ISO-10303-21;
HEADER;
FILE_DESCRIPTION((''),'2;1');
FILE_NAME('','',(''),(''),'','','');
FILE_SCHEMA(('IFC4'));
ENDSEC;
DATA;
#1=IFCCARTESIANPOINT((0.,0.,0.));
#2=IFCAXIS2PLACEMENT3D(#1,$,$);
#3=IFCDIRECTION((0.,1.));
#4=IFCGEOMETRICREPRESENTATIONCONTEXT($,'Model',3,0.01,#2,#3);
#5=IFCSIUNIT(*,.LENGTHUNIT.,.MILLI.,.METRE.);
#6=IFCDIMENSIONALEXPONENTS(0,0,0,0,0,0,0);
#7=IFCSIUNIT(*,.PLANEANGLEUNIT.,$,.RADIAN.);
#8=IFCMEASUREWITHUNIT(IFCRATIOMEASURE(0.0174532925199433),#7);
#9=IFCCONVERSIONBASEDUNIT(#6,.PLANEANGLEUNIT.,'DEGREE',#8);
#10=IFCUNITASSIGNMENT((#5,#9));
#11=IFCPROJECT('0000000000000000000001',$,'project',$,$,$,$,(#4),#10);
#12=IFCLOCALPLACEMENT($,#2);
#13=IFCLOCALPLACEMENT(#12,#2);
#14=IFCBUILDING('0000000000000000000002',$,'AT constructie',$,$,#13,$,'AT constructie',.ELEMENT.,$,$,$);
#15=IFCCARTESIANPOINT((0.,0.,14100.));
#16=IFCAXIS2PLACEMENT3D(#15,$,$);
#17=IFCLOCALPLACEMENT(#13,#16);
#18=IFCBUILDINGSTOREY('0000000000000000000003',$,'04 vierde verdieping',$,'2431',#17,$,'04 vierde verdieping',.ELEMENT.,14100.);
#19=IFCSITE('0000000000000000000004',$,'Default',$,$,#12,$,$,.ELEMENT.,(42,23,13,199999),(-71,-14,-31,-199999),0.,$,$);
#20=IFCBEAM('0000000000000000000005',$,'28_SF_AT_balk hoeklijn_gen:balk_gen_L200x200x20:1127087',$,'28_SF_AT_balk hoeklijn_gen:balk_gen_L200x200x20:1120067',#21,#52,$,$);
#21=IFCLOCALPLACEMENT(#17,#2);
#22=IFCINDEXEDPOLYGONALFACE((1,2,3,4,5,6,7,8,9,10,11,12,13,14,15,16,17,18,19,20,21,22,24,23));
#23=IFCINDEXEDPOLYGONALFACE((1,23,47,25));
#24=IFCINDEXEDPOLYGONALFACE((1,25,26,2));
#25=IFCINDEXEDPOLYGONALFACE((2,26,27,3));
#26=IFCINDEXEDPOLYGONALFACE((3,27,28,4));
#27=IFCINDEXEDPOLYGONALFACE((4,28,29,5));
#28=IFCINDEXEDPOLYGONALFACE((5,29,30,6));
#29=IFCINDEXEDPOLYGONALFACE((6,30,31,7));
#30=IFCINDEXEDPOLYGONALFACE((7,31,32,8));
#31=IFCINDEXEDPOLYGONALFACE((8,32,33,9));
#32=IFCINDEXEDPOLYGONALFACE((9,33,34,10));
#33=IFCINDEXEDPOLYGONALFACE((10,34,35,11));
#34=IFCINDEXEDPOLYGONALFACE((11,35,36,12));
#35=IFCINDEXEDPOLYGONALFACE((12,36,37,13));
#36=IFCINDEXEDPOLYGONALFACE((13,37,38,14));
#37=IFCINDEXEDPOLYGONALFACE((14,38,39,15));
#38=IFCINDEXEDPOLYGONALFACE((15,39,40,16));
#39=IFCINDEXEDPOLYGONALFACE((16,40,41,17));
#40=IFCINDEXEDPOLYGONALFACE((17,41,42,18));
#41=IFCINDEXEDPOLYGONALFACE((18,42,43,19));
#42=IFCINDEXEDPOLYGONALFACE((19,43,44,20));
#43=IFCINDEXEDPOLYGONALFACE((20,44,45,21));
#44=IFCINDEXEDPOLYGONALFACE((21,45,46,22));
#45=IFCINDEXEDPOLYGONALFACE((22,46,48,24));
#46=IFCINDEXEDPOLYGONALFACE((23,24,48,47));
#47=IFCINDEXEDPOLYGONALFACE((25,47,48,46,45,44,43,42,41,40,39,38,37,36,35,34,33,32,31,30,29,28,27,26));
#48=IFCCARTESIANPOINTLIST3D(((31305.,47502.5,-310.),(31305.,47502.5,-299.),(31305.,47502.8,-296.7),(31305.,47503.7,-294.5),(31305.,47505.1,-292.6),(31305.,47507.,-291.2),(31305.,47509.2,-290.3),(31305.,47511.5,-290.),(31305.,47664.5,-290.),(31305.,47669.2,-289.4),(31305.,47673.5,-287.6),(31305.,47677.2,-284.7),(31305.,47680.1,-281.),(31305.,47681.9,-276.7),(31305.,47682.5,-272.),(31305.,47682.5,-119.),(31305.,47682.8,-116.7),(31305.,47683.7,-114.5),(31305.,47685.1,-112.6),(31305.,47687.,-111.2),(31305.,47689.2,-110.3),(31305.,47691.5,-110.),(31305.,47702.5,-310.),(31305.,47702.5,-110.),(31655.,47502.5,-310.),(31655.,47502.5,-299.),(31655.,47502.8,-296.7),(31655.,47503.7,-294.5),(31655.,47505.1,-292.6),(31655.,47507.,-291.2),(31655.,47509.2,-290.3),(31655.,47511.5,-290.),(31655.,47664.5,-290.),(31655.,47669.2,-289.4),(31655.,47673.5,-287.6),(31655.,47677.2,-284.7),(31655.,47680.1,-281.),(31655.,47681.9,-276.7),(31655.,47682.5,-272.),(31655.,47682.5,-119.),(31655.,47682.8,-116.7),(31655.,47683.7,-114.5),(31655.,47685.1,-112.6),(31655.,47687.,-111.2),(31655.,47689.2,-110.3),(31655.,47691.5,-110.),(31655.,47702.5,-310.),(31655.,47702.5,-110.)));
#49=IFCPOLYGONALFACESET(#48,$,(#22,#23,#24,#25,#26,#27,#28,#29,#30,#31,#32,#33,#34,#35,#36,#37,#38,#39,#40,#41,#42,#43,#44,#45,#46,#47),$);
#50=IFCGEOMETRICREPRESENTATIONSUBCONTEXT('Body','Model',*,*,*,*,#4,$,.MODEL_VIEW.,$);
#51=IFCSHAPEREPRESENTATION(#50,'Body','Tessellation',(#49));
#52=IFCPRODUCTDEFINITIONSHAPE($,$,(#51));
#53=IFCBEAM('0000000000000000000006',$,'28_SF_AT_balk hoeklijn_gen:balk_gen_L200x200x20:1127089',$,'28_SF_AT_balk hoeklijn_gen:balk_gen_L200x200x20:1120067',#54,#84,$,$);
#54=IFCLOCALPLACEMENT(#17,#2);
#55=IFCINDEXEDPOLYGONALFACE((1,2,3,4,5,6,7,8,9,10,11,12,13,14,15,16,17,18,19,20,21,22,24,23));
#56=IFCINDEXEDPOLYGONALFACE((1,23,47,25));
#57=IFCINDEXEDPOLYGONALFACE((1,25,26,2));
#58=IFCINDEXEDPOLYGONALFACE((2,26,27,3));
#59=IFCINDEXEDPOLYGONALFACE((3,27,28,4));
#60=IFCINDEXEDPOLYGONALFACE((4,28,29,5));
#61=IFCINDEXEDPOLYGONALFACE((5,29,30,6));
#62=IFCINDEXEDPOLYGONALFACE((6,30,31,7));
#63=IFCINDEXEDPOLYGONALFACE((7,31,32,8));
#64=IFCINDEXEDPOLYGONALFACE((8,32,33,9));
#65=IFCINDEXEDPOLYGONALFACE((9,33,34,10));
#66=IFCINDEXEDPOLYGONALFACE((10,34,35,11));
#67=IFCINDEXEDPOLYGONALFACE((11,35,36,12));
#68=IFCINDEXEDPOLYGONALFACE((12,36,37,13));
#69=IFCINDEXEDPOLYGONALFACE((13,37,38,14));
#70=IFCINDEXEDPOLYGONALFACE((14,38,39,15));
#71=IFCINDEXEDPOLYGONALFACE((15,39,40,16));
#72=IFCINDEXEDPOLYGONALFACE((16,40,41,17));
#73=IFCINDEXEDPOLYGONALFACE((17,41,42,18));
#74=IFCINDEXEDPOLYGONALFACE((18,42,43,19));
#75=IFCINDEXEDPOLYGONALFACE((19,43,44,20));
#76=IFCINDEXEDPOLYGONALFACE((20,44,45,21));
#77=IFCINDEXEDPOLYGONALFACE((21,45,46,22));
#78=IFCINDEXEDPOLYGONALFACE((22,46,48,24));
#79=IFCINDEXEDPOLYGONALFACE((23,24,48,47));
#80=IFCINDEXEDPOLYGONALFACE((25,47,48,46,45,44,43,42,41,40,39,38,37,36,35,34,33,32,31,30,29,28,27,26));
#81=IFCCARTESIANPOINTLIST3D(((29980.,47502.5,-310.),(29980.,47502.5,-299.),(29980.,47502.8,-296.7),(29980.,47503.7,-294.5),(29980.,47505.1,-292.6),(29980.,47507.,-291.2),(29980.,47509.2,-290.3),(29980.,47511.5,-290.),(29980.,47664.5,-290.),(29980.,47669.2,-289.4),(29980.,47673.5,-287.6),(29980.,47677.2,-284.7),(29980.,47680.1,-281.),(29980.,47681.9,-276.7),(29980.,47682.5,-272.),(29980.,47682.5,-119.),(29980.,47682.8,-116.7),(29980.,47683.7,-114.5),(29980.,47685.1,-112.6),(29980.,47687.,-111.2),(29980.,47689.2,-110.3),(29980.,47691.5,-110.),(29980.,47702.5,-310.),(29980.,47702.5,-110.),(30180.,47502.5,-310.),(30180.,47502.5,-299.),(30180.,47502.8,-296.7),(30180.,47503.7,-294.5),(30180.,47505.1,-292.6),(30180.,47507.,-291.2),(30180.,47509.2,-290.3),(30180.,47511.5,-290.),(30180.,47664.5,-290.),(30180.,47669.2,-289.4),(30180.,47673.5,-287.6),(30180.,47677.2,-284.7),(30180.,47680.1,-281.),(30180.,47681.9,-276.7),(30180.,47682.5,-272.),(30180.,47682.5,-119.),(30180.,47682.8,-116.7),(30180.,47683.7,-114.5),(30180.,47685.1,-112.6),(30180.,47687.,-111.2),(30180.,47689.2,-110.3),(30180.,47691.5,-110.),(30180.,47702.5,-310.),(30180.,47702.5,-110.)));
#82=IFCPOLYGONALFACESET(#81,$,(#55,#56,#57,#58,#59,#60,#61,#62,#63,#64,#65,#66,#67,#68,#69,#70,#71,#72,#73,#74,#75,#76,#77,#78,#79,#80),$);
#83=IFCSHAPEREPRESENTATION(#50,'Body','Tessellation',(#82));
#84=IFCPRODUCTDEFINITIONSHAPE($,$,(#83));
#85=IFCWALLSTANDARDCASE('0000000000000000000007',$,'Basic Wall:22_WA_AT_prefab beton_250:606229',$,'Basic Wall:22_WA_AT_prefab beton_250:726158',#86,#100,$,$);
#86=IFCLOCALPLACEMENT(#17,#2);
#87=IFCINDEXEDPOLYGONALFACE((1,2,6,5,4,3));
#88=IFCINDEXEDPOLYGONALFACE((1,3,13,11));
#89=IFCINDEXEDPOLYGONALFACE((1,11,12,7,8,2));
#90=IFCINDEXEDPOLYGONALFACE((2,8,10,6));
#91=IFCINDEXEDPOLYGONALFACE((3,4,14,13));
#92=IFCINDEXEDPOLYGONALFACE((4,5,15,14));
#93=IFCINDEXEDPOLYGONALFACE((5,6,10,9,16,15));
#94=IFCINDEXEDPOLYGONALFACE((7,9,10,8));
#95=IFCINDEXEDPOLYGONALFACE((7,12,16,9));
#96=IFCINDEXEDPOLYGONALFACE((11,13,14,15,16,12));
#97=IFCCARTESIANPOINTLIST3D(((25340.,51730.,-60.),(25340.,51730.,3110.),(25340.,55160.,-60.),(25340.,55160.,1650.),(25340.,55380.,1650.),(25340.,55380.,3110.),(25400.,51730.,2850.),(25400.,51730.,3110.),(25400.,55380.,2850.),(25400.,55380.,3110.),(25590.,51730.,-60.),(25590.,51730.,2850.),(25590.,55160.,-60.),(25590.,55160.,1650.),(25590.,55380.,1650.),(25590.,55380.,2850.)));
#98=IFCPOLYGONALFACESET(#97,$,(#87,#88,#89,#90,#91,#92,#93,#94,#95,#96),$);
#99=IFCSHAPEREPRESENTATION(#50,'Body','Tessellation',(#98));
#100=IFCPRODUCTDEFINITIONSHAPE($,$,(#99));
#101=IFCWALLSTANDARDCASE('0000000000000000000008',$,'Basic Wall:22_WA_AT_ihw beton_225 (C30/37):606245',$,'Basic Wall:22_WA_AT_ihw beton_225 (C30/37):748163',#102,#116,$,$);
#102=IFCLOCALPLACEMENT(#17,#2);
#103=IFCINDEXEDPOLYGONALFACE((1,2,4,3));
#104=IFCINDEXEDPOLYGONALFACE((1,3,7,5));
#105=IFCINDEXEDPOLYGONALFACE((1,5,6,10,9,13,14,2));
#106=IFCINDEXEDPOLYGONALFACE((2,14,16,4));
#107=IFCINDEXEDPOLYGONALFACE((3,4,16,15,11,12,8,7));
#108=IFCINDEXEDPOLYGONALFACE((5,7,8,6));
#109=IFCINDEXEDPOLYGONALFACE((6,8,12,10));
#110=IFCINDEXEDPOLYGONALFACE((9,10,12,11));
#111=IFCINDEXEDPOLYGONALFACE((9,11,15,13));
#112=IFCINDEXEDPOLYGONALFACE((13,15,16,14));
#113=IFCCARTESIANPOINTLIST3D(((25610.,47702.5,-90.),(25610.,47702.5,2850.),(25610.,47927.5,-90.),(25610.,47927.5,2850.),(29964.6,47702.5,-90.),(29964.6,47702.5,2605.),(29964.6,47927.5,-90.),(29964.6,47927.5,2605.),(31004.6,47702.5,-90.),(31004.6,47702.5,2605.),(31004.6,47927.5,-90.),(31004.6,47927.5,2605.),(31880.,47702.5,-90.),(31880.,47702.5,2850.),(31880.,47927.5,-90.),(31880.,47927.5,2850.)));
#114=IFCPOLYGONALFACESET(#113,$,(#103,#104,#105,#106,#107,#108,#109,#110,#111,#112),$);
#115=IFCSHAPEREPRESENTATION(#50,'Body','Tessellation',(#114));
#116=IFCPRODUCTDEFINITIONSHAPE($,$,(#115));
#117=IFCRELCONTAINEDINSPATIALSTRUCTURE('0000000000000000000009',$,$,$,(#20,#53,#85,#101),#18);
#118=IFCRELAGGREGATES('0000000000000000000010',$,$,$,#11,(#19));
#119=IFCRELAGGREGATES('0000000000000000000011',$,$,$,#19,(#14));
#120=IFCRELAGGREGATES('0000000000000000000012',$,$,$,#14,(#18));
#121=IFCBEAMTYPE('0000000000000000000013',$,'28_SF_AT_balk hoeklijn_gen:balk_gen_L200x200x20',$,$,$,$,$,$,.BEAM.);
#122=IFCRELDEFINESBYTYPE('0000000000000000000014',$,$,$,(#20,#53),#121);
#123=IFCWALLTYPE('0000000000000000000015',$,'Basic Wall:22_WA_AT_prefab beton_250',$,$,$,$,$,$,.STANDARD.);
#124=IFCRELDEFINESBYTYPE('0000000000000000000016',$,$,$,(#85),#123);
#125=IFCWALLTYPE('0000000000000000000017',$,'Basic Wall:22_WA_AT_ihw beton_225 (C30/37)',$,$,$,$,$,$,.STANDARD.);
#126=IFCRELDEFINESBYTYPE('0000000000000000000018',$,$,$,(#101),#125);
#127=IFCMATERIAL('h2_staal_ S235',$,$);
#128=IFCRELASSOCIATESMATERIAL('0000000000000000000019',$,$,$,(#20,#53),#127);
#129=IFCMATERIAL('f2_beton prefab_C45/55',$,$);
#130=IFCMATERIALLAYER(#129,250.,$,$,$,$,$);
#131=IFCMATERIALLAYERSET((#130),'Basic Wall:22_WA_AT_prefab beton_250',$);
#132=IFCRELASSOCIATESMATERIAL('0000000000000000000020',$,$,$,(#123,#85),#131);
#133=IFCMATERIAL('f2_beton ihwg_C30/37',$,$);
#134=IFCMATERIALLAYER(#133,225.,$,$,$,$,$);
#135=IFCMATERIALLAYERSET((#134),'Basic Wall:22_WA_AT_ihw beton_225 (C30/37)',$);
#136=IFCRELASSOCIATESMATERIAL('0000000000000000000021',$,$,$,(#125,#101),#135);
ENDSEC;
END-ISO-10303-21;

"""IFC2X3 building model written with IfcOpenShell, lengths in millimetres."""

from ifc_helpers import new_model, entity, si_unit, converted_unit, direction, frame, frame_2d, origin, origin_2d_with_axis, place, context, subcontext, project, spatial, polyline, circle_curve, parameter, trimmed, segment, composite_curve, rectangle, outline, extrude, material, layer, layer_set, layer_usage, type_object, element, save


model = new_model("IFC2X3")

# Units and contexts
model_context = context("Model", 3, precision=0.01, world=origin(), true_north=direction((0.0, 1.0)))
body_context = subcontext(model_context, "Body", "Model", "MODEL_VIEW")
ifc_project = project(units=[si_unit("LENGTHUNIT", "METRE", prefix="MILLI"), converted_unit("PLANEANGLEUNIT", "DEGREE", entity("IfcRatioMeasure", 0.0174532925199433), si_unit("PLANEANGLEUNIT", "RADIAN"), dimensions=[0, 0, 0, 0, 0, 0, 0])], contexts=[model_context])

# Site, building, storey
site_placement = place(None, origin())
site = spatial("IfcSite", under=ifc_project, at=site_placement, Name="Default", CompositionType="ELEMENT", RefLatitude=(42, 23, 13, 199999), RefLongitude=(-71, -14, -31, -199999), RefElevation=0.0)
building_placement = place(site_placement, origin())
building = spatial("IfcBuilding", under=site, at=building_placement, Name="AT constructie", LongName="AT constructie", CompositionType="ELEMENT")
storey_placement = place(building_placement, frame((0.0, 0.0, 14100.0)))
storey = spatial("IfcBuildingStorey", under=building, at=storey_placement, Name="04 vierde verdieping", ObjectType="2431", LongName="04 vierde verdieping", CompositionType="ELEMENT", Elevation=14100.0)

# Shared definitions
ifc_material_1 = material(Name="f2_beton prefab_C45/55")

# Beams
ifc_material_2 = material(Name="h2_staal_ S235")
beam_type_1 = type_object("IfcBeamType", Name="28_SF_AT_balk hoeklijn_gen:balk_gen_L200x200x20", PredefinedType="BEAM")
beam_1_placement = place(storey_placement, frame((31655.0, 47702.5, -70.0), z_axis=(0.0, 0.0, 1.0), x_axis=(-1.0, 0.0, 0.0)))
element("IfcBeam", 1, at=beam_1_placement, inside=storey, type_object=beam_type_1, material=ifc_material_2, Name="28_SF_AT_balk hoeklijn_gen:balk_gen_L200x200x20:1127087", ObjectType="28_SF_AT_balk hoeklijn_gen:balk_gen_L200x200x20:1120067", context=body_context, shape_type="SweptSolid", body=[
    extrude(outline(composite_curve([segment(polyline([(-124.4, -75.6), (75.6, -75.6)]), True, "CONTINUOUS"), segment(polyline([(75.6, -75.6), (75.6, 124.4)]), True, "CONTINUOUS"), segment(polyline([(75.6, 124.4), (64.6, 124.4)]), True, "CONTINUOUS"), segment(trimmed(circle_curve(frame_2d((64.6, 115.4), x_axis=(0.0, 1.0)), 9.0), [parameter(0.0)], [parameter(90.0)], True, "PARAMETER"), True, "CONTINUOUS"), segment(polyline([(55.6, 115.4), (55.6, -37.6)]), True, "CONTINUOUS"), segment(trimmed(circle_curve(frame_2d((37.6, -37.6), x_axis=(1.0, 0.0)), 18.0), [parameter(270.0)], [parameter(0.0)], True, "PARAMETER"), False, "CONTINUOUS"), segment(polyline([(37.6, -55.6), (-115.4, -55.6)]), True, "CONTINUOUS"), segment(trimmed(circle_curve(frame_2d((-115.4, -64.6), x_axis=(0.0, 1.0)), 9.0), [parameter(0.0)], [parameter(90.0)], True, "PARAMETER"), True, "CONTINUOUS"), segment(polyline([(-124.4, -64.6), (-124.4, -75.6)]), True, "CONTINUOUS")], self_intersect=False)), frame((0.0, 75.6, -164.4), z_axis=(1.0, 0.0, 0.0), x_axis=(0.0, 0.0, -1.0)), (0.0, 0.0, 1.0), 350.0),
])
beam_2_placement = place(storey_placement, frame((30180.0, 47702.5, -70.0), z_axis=(0.0, 0.0, 1.0), x_axis=(-1.0, 0.0, 0.0)))
element("IfcBeam", 2, at=beam_2_placement, inside=storey, type_object=beam_type_1, material=ifc_material_2, Name="28_SF_AT_balk hoeklijn_gen:balk_gen_L200x200x20:1127089", ObjectType="28_SF_AT_balk hoeklijn_gen:balk_gen_L200x200x20:1120067", context=body_context, shape_type="SweptSolid", body=[
    extrude(outline(composite_curve([segment(polyline([(-124.4, -75.6), (75.6, -75.6)]), True, "CONTINUOUS"), segment(polyline([(75.6, -75.6), (75.6, 124.4)]), True, "CONTINUOUS"), segment(polyline([(75.6, 124.4), (64.6, 124.4)]), True, "CONTINUOUS"), segment(trimmed(circle_curve(frame_2d((64.6, 115.4), x_axis=(0.0, 1.0)), 9.0), [parameter(0.0)], [parameter(90.0)], True, "PARAMETER"), True, "CONTINUOUS"), segment(polyline([(55.6, 115.4), (55.6, -37.6)]), True, "CONTINUOUS"), segment(trimmed(circle_curve(frame_2d((37.6, -37.6), x_axis=(1.0, 0.0)), 18.0), [parameter(270.0)], [parameter(0.0)], True, "PARAMETER"), False, "CONTINUOUS"), segment(polyline([(37.6, -55.6), (-115.4, -55.6)]), True, "CONTINUOUS"), segment(trimmed(circle_curve(frame_2d((-115.4, -64.6), x_axis=(0.0, 1.0)), 9.0), [parameter(0.0)], [parameter(90.0)], True, "PARAMETER"), True, "CONTINUOUS"), segment(polyline([(-124.4, -64.6), (-124.4, -75.6)]), True, "CONTINUOUS")], self_intersect=False)), frame((0.0, 75.6, -164.4), z_axis=(1.0, 0.0, 0.0), x_axis=(0.0, 0.0, -1.0)), (0.0, 0.0, 1.0), 200.0),
])

# Wall, openings
ifc_layer_1 = layer(ifc_material_1, 250.0)
ifc_layer_set_1 = layer_set([ifc_layer_1], Name="Basic Wall:22_WA_AT_prefab beton_250")
ifc_layer_usage_1 = layer_usage(ifc_layer_set_1, "AXIS2", "NEGATIVE", 125.0)
wall_type_1 = type_object("IfcWallType", Name="Basic Wall:22_WA_AT_prefab beton_250", PredefinedType="STANDARD", material=ifc_layer_set_1)
wall_1_placement = place(storey_placement, frame((25465.0, 55380.0, -60.0), z_axis=(0.0, 0.0, 1.0), x_axis=(0.0, -1.0, 0.0)))
wall_1 = element("IfcWallStandardCase", 3, at=wall_1_placement, inside=storey, type_object=wall_type_1, material=ifc_layer_usage_1, Name="Basic Wall:22_WA_AT_prefab beton_250:606229", ObjectType="Basic Wall:22_WA_AT_prefab beton_250:726158", context=body_context, shape_type="SweptSolid", body=[
    extrude(rectangle(XDim=3650.0, YDim=250.0, at=frame_2d((1825.0, 0.0), x_axis=(-1.0, 0.0))), origin(), (0.0, 0.0, 1.0), 3170.0),
])
opening_1_placement = place(wall_1_placement, origin())
element("IfcOpeningElement", 4, at=opening_1_placement, cuts=wall_1, ObjectType="Recess", context=body_context, shape_type="SweptSolid", body=[
    extrude(rectangle(XDim=260.0, YDim=3900.0, at=frame_2d((0.0, 0.0), x_axis=(0.0, 1.0))), frame((1950.0, -65.0, 3040.0), z_axis=(0.0, 1.0, 0.0), x_axis=(1.0, 0.0, 0.0)), (0.0, 0.0, 1.0), 190.0),
])
opening_2_placement = place(wall_1_placement, origin())
element("IfcOpeningElement", 5, at=opening_2_placement, cuts=wall_1, ObjectType="Opening", context=body_context, shape_type="SweptSolid", body=[
    extrude(rectangle(XDim=1710.0, YDim=220.0, at=origin_2d_with_axis()), frame((110.0, 125.0, 855.0), z_axis=(0.0, -1.0, 0.0), x_axis=(0.0, 0.0, -1.0)), (0.0, 0.0, 1.0), 250.0),
])

# Wall, opening
ifc_material_3 = material(Name="f2_beton ihwg_C30/37")
ifc_layer_2 = layer(ifc_material_3, 225.0)
ifc_layer_set_2 = layer_set([ifc_layer_2], Name="Basic Wall:22_WA_AT_ihw beton_225 (C30/37)")
ifc_layer_usage_2 = layer_usage(ifc_layer_set_2, "AXIS2", "NEGATIVE", 112.5)
wall_type_2 = type_object("IfcWallType", Name="Basic Wall:22_WA_AT_ihw beton_225 (C30/37)", PredefinedType="STANDARD", material=ifc_layer_set_2)
wall_2_placement = place(storey_placement, frame((25610.0, 47815.0, -90.0)))
wall_2 = element("IfcWallStandardCase", 6, at=wall_2_placement, inside=storey, type_object=wall_type_2, material=ifc_layer_usage_2, Name="Basic Wall:22_WA_AT_ihw beton_225 (C30/37):606245", ObjectType="Basic Wall:22_WA_AT_ihw beton_225 (C30/37):748163", context=body_context, shape_type="SweptSolid", body=[
    extrude(rectangle(XDim=6270.0, YDim=225.0, at=frame_2d((3135.0, 0.0), x_axis=(-1.0, 0.0))), origin(), (0.0, 0.0, 1.0), 2940.0),
])
opening_3_placement = place(wall_2_placement, origin())
element("IfcOpeningElement", 7, at=opening_3_placement, cuts=wall_2, ObjectType="Opening", context=body_context, shape_type="SweptSolid", body=[
    extrude(rectangle(XDim=2695.0, YDim=1040.0, at=frame_2d((0.0, 0.0), x_axis=(1.0, 0.0))), frame((4874.6, -1411.5, 1347.5), z_axis=(0.0, 1.0, 0.0), x_axis=(0.0, 0.0, -1.0)), (0.0, 0.0, 1.0), 3048.0),
])

save(model, "model.ifc")
